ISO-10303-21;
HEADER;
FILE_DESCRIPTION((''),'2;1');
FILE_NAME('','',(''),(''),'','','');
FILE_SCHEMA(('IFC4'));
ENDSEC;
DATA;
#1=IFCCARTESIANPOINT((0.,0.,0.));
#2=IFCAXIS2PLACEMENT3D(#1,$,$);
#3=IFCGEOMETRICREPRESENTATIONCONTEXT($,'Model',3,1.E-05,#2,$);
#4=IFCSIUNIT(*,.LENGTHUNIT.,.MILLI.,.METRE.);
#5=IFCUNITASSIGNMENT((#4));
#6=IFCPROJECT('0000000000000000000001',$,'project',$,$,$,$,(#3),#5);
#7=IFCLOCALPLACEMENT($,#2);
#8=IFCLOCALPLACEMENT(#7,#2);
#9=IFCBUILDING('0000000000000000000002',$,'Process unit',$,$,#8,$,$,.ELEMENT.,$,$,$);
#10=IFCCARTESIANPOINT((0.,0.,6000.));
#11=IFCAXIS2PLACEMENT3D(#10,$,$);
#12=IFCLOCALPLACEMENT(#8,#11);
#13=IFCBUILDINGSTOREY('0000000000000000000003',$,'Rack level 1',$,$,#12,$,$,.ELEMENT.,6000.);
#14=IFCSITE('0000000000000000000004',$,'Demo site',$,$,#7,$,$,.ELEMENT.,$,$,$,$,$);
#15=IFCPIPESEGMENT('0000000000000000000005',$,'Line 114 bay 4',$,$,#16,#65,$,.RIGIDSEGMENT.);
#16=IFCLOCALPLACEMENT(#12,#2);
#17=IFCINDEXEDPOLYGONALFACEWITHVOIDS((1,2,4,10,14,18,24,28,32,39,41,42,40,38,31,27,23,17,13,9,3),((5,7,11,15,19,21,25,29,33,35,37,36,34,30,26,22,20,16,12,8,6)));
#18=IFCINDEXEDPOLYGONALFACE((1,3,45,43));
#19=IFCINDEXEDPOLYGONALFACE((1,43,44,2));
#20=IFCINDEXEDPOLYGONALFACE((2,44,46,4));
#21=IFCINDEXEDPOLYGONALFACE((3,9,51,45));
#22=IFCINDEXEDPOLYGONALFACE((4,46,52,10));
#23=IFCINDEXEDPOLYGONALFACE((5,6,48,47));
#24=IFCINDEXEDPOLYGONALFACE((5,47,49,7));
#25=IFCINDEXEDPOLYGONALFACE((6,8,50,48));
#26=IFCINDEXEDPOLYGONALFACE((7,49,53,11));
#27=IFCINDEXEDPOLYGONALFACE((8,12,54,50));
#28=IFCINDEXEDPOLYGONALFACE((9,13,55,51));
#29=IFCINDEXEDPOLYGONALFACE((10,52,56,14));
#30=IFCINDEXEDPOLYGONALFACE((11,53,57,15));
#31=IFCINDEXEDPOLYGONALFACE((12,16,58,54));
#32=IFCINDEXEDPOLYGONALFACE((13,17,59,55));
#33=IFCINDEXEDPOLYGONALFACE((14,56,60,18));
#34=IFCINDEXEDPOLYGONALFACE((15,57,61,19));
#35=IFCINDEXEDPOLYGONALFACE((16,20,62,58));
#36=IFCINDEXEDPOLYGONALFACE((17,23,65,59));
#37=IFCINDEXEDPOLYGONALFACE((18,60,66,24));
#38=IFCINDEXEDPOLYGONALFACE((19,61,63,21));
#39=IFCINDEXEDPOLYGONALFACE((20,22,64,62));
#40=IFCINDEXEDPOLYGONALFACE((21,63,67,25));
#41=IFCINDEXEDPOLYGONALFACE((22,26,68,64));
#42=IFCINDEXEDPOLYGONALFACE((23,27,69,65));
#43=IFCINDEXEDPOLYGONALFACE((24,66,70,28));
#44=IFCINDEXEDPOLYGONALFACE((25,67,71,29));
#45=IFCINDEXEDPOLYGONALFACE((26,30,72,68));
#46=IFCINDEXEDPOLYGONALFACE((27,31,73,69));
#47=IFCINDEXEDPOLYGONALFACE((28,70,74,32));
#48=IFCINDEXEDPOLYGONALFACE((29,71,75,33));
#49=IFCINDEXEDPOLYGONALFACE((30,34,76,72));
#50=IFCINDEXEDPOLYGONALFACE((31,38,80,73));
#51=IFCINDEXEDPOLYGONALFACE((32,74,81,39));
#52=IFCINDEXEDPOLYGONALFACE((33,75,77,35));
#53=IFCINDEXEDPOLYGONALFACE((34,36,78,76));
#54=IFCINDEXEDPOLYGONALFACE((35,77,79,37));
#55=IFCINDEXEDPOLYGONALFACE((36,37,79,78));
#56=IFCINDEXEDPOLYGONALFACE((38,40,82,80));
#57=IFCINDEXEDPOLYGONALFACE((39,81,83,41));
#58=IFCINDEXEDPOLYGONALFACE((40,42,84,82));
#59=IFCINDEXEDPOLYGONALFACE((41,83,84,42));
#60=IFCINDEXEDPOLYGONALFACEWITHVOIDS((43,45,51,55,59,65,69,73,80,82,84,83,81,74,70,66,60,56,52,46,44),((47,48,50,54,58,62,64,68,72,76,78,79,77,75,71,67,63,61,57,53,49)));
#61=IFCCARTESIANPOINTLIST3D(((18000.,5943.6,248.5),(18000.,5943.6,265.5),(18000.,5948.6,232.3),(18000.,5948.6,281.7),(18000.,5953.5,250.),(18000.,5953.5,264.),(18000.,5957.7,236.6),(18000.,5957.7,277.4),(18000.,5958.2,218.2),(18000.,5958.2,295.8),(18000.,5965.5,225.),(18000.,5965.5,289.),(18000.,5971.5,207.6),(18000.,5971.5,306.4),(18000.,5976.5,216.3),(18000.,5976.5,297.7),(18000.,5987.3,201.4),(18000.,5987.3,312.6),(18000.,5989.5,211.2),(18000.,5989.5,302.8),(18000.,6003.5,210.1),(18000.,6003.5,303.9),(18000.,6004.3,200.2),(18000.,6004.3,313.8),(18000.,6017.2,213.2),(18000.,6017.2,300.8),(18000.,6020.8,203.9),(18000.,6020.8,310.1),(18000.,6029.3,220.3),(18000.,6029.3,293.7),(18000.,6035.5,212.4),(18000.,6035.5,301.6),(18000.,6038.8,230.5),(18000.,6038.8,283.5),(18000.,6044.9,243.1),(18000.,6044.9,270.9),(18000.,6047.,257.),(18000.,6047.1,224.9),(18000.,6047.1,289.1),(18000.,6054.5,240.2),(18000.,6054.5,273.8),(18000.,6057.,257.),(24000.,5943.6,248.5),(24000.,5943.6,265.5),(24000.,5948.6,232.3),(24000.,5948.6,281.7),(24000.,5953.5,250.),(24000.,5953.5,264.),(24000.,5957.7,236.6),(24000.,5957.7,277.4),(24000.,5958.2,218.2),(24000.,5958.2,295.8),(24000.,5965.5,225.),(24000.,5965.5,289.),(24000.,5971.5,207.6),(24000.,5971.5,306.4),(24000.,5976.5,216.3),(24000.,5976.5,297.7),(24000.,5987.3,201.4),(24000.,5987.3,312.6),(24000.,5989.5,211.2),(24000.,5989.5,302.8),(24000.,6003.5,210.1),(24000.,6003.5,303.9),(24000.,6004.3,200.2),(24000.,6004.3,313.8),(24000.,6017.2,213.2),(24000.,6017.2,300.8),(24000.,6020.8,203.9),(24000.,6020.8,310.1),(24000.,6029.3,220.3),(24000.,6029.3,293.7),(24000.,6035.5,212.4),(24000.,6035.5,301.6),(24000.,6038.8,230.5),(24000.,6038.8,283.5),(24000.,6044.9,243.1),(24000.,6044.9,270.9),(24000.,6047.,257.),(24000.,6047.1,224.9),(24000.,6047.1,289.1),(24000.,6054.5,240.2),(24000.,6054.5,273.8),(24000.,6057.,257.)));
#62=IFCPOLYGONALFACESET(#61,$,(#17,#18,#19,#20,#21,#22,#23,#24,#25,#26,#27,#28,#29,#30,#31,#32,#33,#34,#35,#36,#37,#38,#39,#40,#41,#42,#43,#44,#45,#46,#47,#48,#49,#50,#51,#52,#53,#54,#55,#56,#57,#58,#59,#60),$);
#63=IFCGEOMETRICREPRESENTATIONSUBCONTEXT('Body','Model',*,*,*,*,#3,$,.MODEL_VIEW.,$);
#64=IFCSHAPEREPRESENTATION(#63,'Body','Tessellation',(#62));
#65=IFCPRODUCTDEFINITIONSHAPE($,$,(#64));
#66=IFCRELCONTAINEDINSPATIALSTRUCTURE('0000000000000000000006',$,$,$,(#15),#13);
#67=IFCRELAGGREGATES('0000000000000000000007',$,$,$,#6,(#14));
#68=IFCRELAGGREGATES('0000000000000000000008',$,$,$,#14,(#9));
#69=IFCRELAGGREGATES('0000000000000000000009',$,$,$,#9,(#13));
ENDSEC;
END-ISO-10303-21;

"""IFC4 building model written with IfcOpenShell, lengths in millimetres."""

from ifc_helpers import new_model, si_unit, frame, origin, place, context, subcontext, project, spatial, hollow_circle, extrude, element, save


model = new_model("IFC4")

# Units and contexts
model_context = context("Model", 3, precision=1e-05, world=origin())
body_context = subcontext(model_context, "Body", "Model", "MODEL_VIEW")
ifc_project = project(units=[si_unit("LENGTHUNIT", "METRE", prefix="MILLI")], contexts=[model_context])

# Site, building, storey
site_placement = place(None, origin())
site = spatial("IfcSite", under=ifc_project, at=site_placement, Name="Demo site", CompositionType="ELEMENT")
building_placement = place(site_placement, origin())
building = spatial("IfcBuilding", under=site, at=building_placement, Name="Process unit", CompositionType="ELEMENT")
storey_placement = place(building_placement, frame((0.0, 0.0, 6000.0)))
storey = spatial("IfcBuildingStorey", under=building, at=storey_placement, Name="Rack level 1", CompositionType="ELEMENT", Elevation=6000.0)

# Pipe segment
pipe_segment_1_placement = place(storey_placement, frame((18000.0, 6000.0, 257.0)))
element("IfcPipeSegment", 1, at=pipe_segment_1_placement, inside=storey, Name="Line 114 bay 4", PredefinedType="RIGIDSEGMENT", context=body_context, shape_type="SweptSolid", body=[
    extrude(hollow_circle(Radius=57.0, WallThickness=10.0), frame((0.0, 0.0, 0.0), z_axis=(1.0, 0.0, 0.0), x_axis=(0.0, 1.0, 0.0)), (0.0, 0.0, 1.0), 6000.0),
])

save(model, "model.ifc")
